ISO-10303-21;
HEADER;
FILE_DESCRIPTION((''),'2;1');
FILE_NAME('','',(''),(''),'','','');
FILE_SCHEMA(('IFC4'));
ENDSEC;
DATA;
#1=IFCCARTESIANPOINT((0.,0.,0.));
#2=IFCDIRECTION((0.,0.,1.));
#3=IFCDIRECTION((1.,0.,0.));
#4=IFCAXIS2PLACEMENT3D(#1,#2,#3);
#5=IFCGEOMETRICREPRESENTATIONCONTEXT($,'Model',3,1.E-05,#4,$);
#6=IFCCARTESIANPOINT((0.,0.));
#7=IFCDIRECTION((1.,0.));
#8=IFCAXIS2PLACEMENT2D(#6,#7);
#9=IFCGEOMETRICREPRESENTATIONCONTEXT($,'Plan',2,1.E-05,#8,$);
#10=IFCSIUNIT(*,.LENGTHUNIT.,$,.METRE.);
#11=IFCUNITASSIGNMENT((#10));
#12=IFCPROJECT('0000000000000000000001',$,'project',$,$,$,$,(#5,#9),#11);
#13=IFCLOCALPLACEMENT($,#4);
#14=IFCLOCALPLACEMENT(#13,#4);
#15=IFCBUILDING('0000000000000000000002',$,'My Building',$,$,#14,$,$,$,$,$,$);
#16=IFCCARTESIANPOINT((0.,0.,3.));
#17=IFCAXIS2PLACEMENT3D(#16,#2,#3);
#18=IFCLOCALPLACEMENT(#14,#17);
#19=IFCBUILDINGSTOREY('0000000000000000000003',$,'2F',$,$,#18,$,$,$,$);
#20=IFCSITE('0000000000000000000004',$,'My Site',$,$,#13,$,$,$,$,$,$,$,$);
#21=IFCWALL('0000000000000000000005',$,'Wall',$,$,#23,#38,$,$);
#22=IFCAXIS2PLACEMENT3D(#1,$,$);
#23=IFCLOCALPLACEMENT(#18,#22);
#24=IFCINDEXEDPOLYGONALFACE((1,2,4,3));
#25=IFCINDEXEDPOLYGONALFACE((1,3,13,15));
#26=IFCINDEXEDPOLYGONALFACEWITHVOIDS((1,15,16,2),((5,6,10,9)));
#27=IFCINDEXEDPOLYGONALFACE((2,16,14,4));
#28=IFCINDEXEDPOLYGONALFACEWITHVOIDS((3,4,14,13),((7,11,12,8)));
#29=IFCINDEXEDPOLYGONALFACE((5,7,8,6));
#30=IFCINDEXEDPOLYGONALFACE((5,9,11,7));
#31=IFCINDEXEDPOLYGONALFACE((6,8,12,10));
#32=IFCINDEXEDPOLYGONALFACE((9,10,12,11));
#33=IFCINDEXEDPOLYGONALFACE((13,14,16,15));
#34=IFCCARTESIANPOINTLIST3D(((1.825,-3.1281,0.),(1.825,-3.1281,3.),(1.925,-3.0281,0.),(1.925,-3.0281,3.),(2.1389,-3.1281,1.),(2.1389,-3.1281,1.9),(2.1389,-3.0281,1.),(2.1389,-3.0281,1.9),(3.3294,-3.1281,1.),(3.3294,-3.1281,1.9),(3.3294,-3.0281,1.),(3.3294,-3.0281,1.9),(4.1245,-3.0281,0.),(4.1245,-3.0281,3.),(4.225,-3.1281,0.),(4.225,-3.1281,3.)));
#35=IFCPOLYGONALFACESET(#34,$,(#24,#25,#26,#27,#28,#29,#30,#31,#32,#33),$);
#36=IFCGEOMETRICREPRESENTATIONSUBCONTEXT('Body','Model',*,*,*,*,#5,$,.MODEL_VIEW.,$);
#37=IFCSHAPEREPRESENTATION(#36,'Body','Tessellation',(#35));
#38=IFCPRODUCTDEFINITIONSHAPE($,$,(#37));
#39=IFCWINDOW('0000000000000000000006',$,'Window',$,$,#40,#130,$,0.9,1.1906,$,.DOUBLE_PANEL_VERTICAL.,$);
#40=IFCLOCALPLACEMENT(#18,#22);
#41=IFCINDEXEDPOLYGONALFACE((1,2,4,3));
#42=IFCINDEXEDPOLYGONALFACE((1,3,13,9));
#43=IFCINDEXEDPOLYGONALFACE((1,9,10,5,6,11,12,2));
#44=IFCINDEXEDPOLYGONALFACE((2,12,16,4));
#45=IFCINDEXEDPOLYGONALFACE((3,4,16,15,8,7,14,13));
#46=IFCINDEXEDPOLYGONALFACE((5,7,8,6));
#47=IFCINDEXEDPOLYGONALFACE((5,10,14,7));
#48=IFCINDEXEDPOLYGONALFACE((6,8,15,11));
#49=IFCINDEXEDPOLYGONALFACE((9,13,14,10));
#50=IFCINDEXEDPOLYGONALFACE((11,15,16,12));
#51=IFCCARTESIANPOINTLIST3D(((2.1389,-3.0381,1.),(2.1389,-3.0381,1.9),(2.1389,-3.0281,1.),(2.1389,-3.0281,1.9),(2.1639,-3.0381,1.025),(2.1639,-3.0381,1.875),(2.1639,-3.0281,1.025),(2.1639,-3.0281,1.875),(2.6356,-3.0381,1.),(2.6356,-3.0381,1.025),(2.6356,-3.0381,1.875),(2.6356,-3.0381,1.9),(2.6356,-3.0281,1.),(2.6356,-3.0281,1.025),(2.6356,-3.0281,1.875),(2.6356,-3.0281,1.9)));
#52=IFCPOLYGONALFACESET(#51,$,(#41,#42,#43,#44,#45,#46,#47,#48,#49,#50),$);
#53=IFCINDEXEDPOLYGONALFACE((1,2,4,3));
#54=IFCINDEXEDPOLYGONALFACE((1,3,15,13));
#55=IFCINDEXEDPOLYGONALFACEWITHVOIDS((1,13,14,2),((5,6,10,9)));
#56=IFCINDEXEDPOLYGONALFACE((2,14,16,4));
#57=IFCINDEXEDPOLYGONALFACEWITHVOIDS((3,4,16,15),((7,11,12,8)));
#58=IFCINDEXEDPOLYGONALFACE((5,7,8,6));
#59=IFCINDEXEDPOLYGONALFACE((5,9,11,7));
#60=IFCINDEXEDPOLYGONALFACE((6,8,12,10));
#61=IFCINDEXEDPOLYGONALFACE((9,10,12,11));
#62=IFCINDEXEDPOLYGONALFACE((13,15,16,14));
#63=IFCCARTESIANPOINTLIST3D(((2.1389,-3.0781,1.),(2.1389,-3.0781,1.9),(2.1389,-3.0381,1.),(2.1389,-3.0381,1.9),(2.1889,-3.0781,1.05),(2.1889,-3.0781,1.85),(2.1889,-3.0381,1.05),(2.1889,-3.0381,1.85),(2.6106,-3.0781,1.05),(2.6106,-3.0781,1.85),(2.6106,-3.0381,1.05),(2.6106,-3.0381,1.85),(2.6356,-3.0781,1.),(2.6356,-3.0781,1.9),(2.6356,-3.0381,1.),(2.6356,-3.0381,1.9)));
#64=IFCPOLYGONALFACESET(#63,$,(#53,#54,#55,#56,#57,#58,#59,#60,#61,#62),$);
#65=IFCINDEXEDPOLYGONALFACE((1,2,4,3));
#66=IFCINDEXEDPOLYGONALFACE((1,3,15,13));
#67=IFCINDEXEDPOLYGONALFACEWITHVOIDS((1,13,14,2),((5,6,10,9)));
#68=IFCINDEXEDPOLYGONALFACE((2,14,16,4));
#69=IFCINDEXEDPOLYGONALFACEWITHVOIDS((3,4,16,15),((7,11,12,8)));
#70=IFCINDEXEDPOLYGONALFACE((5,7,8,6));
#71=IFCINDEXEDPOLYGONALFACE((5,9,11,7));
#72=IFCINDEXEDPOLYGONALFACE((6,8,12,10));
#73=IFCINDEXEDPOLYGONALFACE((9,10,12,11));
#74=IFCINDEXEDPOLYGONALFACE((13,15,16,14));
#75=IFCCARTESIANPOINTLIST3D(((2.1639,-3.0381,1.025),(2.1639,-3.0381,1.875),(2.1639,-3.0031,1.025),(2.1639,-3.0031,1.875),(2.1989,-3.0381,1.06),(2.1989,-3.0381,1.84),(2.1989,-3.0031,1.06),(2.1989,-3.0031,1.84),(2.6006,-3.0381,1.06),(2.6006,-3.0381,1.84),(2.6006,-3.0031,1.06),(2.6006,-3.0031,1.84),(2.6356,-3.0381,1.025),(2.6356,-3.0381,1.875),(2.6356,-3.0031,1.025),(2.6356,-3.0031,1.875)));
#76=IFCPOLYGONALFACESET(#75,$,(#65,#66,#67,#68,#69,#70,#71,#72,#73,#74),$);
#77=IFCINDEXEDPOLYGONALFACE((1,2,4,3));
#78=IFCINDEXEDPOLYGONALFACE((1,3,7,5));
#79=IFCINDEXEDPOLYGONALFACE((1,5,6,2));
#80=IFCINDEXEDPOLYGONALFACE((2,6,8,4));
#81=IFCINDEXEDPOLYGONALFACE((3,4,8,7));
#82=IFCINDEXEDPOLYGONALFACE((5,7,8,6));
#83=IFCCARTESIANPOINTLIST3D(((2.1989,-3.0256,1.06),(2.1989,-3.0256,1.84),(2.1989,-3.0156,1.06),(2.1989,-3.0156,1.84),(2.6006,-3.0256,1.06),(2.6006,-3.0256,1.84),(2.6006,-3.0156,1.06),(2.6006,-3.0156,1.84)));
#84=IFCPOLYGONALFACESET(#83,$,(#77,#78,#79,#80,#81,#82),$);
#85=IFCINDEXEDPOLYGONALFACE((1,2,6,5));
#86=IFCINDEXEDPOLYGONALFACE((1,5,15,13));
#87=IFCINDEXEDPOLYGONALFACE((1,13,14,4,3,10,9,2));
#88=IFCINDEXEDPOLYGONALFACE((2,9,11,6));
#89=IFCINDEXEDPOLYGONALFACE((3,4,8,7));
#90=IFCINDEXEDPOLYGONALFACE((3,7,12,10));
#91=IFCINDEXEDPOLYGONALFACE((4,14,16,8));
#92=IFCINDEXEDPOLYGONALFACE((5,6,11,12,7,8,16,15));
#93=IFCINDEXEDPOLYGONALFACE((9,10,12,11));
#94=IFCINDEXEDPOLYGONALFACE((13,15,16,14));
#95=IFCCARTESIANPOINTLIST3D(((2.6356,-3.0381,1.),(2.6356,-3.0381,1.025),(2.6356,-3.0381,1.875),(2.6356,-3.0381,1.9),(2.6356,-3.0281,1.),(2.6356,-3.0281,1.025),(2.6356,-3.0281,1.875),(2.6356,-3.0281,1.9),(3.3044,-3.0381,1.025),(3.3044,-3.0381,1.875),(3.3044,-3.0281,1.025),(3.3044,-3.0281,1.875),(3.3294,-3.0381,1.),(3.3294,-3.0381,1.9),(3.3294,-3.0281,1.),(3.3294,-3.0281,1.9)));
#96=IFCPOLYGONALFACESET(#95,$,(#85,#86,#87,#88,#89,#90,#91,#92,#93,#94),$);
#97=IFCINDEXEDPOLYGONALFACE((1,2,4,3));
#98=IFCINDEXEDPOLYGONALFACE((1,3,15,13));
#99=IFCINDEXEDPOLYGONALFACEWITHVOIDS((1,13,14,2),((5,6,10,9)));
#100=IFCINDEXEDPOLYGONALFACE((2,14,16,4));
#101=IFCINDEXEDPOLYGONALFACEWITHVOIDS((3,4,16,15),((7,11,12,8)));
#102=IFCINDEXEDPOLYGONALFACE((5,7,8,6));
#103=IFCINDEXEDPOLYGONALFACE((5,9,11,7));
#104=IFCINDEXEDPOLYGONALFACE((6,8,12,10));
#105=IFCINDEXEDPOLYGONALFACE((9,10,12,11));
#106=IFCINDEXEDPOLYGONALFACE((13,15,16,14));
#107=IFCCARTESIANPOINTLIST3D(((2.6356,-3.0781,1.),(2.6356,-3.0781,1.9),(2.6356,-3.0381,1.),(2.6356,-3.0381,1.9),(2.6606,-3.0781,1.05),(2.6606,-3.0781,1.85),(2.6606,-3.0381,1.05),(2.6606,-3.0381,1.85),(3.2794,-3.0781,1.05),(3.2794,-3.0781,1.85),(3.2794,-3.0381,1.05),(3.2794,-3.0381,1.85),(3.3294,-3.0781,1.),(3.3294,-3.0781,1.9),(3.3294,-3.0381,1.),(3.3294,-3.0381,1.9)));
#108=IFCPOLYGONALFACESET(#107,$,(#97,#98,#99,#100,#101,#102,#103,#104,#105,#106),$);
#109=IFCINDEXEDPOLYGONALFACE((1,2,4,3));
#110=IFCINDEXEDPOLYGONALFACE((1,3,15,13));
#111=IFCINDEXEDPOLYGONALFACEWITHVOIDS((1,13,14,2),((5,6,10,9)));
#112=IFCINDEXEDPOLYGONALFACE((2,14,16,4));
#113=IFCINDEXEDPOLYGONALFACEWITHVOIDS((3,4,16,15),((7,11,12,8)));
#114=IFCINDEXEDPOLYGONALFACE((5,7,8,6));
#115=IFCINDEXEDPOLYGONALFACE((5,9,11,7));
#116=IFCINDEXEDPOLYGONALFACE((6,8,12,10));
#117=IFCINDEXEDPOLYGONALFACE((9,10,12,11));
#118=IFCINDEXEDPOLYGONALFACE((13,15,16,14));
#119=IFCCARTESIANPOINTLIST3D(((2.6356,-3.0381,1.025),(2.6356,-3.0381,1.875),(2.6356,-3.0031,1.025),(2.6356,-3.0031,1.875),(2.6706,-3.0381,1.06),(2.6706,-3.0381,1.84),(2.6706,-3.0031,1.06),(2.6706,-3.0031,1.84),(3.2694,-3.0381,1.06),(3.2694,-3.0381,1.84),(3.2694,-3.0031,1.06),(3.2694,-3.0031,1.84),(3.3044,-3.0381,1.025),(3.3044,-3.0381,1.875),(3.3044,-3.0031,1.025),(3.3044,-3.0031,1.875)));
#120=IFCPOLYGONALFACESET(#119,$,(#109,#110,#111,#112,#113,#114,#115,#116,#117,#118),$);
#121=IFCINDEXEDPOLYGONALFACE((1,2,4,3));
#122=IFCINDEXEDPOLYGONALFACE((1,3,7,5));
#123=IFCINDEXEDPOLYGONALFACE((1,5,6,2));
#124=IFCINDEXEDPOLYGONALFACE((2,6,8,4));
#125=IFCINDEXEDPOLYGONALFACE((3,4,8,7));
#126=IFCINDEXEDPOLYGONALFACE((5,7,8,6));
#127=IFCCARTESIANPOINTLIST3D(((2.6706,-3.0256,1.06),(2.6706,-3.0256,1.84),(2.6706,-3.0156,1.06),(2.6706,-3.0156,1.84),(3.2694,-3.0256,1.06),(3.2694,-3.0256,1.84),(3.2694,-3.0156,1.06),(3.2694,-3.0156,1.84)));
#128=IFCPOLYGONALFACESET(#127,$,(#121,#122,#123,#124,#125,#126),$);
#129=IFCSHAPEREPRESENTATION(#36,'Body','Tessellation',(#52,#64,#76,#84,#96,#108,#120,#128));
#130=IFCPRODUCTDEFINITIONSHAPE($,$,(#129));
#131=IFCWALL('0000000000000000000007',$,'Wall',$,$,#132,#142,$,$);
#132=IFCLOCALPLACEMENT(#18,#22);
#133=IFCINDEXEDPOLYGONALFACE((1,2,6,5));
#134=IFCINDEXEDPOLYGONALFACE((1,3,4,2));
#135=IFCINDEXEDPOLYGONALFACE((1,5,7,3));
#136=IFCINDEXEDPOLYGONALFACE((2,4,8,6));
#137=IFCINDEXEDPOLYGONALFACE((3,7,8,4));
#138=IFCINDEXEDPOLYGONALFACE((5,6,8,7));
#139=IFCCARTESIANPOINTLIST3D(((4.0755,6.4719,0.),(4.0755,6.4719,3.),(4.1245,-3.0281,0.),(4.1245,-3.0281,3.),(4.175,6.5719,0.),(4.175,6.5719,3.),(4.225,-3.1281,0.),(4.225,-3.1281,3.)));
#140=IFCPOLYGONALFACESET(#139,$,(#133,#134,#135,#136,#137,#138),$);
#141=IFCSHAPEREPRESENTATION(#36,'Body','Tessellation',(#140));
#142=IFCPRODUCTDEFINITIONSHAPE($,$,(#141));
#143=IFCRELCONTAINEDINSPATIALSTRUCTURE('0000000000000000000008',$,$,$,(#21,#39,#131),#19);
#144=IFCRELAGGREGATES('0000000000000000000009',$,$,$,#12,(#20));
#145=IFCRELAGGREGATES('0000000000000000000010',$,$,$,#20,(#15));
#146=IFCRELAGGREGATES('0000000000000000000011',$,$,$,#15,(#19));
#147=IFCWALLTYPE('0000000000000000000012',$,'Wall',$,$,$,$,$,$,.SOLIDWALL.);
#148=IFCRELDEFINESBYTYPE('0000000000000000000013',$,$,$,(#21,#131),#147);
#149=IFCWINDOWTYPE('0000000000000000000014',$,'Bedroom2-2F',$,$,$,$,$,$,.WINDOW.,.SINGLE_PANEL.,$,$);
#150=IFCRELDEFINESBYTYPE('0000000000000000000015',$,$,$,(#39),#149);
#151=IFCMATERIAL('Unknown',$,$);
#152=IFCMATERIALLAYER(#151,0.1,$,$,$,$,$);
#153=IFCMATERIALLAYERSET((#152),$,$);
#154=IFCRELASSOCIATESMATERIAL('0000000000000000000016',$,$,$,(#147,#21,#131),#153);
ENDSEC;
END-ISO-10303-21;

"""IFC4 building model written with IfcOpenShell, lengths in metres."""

from ifc_helpers import new_model, entity, si_unit, frame, origin_with_axes, origin_2d_with_axis, place, context, subcontext, project, spatial, line, indexed_curve, outline, extrude, shape, source, transform, mapped, material, layer, layer_set, layer_usage, type_object, type_shapes, element, fill, save


model = new_model("IFC4")

# Units and contexts
model_context = context("Model", 3, precision=1e-05, world=origin_with_axes())
plan_context = context("Plan", 2, precision=1e-05, world=origin_2d_with_axis())
body_context_1 = subcontext(model_context, "Body", "Model", "MODEL_VIEW")
body_context_2 = subcontext(plan_context, "Body", "Plan", "PLAN_VIEW")
ifc_project = project(units=[si_unit("LENGTHUNIT", "METRE")], contexts=[model_context, plan_context])

# Site, building, storey
site_placement = place(None, origin_with_axes())
site = spatial("IfcSite", under=ifc_project, at=site_placement, Name="My Site")
building_placement = place(site_placement, origin_with_axes())
building = spatial("IfcBuilding", under=site, at=building_placement, Name="My Building")
storey_placement = place(building_placement, frame((0.0, 0.0, 3.0), z_axis=(0.0, 0.0, 1.0), x_axis=(1.0, 0.0, 0.0)))
storey = spatial("IfcBuildingStorey", under=building, at=storey_placement, Name="2F")

# Shared definitions
ifc_material = material(Name="Unknown")

# Shared definitions
ifc_layer_1 = layer(ifc_material, 0.1)
ifc_layer_set_1 = layer_set([ifc_layer_1])
wall_type = type_object("IfcWallType", Name="Wall", PredefinedType="SOLIDWALL", material=ifc_layer_set_1)

# Wall, opening, window
ifc_layer_usage_1 = layer_usage(ifc_layer_set_1, "AXIS2", "POSITIVE", 0.0)
wall_1_placement = place(storey_placement, frame((1.825, -3.1281, 0.0), z_axis=(0.0, 0.0, 1.0), x_axis=(1.0, 0.0, 0.0)))
wall_1 = element("IfcWall", 1, at=wall_1_placement, inside=storey, type_object=wall_type, material=ifc_layer_usage_1, Name="Wall", context=body_context_1, shape_type="SweptSolid", body=[
    extrude(outline(indexed_curve([(0.0, 0.0), (0.1, 0.1), (2.2995, 0.1), (2.4, 0.0)], segments=[line(1, 2, 3, 4, 1)])), origin_with_axes(), (0.0, 0.0, 1.0), 3.0),
])
shared_shape_1 = source(origin_with_axes(), body_context_1, "Body", "SweptSolid", [
    extrude(outline(indexed_curve([(0.0, 0.0), (1.1906, 0.0), (1.1906, 0.9), (0.0, 0.9)], segments=[line(1, 2, 3, 4, 1)])), frame((0.0, -0.6, 0.0), z_axis=(0.0, -1.0, 0.0), x_axis=(1.0, 0.0, 0.0)), (0.0, 0.0, -1.0), 1.2),
])
opening_1_placement = place(wall_1_placement, frame((0.3139, 0.0, 1.0), z_axis=(0.0, 0.0, 1.0), x_axis=(1.0, 0.0, 0.0)))
opening_1 = element("IfcOpeningElement", 2, at=opening_1_placement, cuts=wall_1, PredefinedType="OPENING", context=body_context_1, shape_type="MappedRepresentation", body=[
    mapped(shared_shape_1, transform((0.0, 0.0, 0.0), x_axis=(1.0, 0.0, 0.0), y_axis=(0.0, 1.0, 0.0), z_axis=(0.0, 0.0, 1.0), scale=1.0)),
])
window_type_1 = type_object("IfcWindowType", Name="Bedroom2-2F", PartitioningType="SINGLE_PANEL", PredefinedType="WINDOW")
shared_shape_2 = source(origin_with_axes(), body_context_1, "Body", "SweptSolid", [
    extrude(outline(indexed_curve([(0.4967, 0.0), (0.0, 0.0), (0.0, 0.9), (0.4967, 0.9), (0.4967, 0.875), (0.025, 0.875), (0.025, 0.025), (0.4967, 0.025)], segments=[line(1, 2, 3, 4, 5, 6, 7, 8, 1)])), frame((0.0, 0.09, 0.0), z_axis=(0.0, -1.0, 0.0), x_axis=(1.0, 0.0, 0.0)), (0.0, 0.0, -1.0), 0.01),
    extrude(outline(indexed_curve([(0.0, 0.0), (0.4967, 0.0), (0.4967, 0.9), (0.0, 0.9)], segments=[line(1, 2, 3, 4, 1)]), holes=[indexed_curve([(0.05, 0.05), (0.4717, 0.05), (0.4717, 0.85), (0.05, 0.85)], segments=[line(1, 2, 3, 4, 1)])]), frame((0.0, 0.05, 0.0), z_axis=(0.0, -1.0, 0.0), x_axis=(1.0, 0.0, 0.0)), (0.0, 0.0, -1.0), 0.04),
    extrude(outline(indexed_curve([(0.0, 0.0), (0.4717, 0.0), (0.4717, 0.85), (0.0, 0.85)], segments=[line(1, 2, 3, 4, 1)]), holes=[indexed_curve([(0.035, 0.035), (0.4367, 0.035), (0.4367, 0.815), (0.035, 0.815)], segments=[line(1, 2, 3, 4, 1)])]), frame((0.025, 0.09, 0.025), z_axis=(0.0, -1.0, 0.0), x_axis=(1.0, 0.0, 0.0)), (0.0, 0.0, -1.0), 0.035),
    extrude(outline(indexed_curve([(0.035, 0.035), (0.4367, 0.035), (0.4367, 0.815), (0.035, 0.815)], segments=[line(1, 2, 3, 4, 1)])), frame((0.025, 0.1025, 0.025), z_axis=(0.0, -1.0, 0.0), x_axis=(1.0, 0.0, 0.0)), (0.0, 0.0, -1.0), 0.01),
    extrude(outline(indexed_curve([(0.0, 0.9), (0.6938, 0.9), (0.6938, 0.0), (0.0, 0.0), (0.0, 0.025), (0.6688, 0.025), (0.6688, 0.875), (0.0, 0.875)], segments=[line(1, 2, 3, 4, 5, 6, 7, 8, 1)])), frame((0.4967, 0.09, 0.0), z_axis=(0.0, -1.0, 0.0), x_axis=(1.0, 0.0, 0.0)), (0.0, 0.0, -1.0), 0.01),
    extrude(outline(indexed_curve([(0.0, 0.0), (0.6938, 0.0), (0.6938, 0.9), (0.0, 0.9)], segments=[line(1, 2, 3, 4, 1)]), holes=[indexed_curve([(0.025, 0.05), (0.6438, 0.05), (0.6438, 0.85), (0.025, 0.85)], segments=[line(1, 2, 3, 4, 1)])]), frame((0.4967, 0.05, 0.0), z_axis=(0.0, -1.0, 0.0), x_axis=(1.0, 0.0, 0.0)), (0.0, 0.0, -1.0), 0.04),
    extrude(outline(indexed_curve([(0.0, 0.0), (0.6688, 0.0), (0.6688, 0.85), (0.0, 0.85)], segments=[line(1, 2, 3, 4, 1)]), holes=[indexed_curve([(0.035, 0.035), (0.6338, 0.035), (0.6338, 0.815), (0.035, 0.815)], segments=[line(1, 2, 3, 4, 1)])]), frame((0.4967, 0.09, 0.025), z_axis=(0.0, -1.0, 0.0), x_axis=(1.0, 0.0, 0.0)), (0.0, 0.0, -1.0), 0.035),
    extrude(outline(indexed_curve([(0.035, 0.035), (0.6338, 0.035), (0.6338, 0.815), (0.035, 0.815)], segments=[line(1, 2, 3, 4, 1)])), frame((0.4967, 0.1025, 0.025), z_axis=(0.0, -1.0, 0.0), x_axis=(1.0, 0.0, 0.0)), (0.0, 0.0, -1.0), 0.01),
])
shared_shape_3 = source(origin_with_axes(), body_context_2, "Body", "Curve2D", [
    entity("IfcIndexedPolyCurve", entity("IfcCartesianPointList2D", [[0.05, 0.05], [0.4717, 0.05]])),
    entity("IfcIndexedPolyCurve", entity("IfcCartesianPointList2D", [[0.0, 0.1], [0.025, 0.1], [0.025, 0.09], [0.05, 0.09], [0.05, 0.05], [0.0, 0.05]]), [entity("IfcLineIndex", [1, 2, 3, 4, 5, 6, 1])]),
    entity("IfcIndexedPolyCurve", entity("IfcCartesianPointList2D", [[0.4967, 0.1], [0.4967, 0.1], [0.4967, 0.09], [0.4717, 0.09], [0.4717, 0.05], [0.4967, 0.05]])),
    entity("IfcIndexedPolyCurve", entity("IfcCartesianPointList2D", [[0.025, 0.09], [0.06, 0.09], [0.06, 0.125], [0.025, 0.125]]), [entity("IfcLineIndex", [1, 2, 3, 4, 1])]),
    entity("IfcIndexedPolyCurve", entity("IfcCartesianPointList2D", [[0.4967, 0.09], [0.4617, 0.09], [0.4617, 0.125], [0.4967, 0.125]]), [entity("IfcLineIndex", [1, 2, 3, 4, 1])]),
    entity("IfcIndexedPolyCurve", entity("IfcCartesianPointList2D", [[0.06, 0.09], [0.4617, 0.09]])),
    entity("IfcIndexedPolyCurve", entity("IfcCartesianPointList2D", [[0.06, 0.125], [0.4617, 0.125]])),
    entity("IfcIndexedPolyCurve", entity("IfcCartesianPointList2D", [[0.06, 0.1075], [0.4617, 0.1075]])),
    entity("IfcIndexedPolyCurve", entity("IfcCartesianPointList2D", [[0.5217, 0.05], [1.1406, 0.05]])),
    entity("IfcIndexedPolyCurve", entity("IfcCartesianPointList2D", [[0.4967, 0.1], [0.4967, 0.1], [0.4967, 0.09], [0.5217, 0.09], [0.5217, 0.05], [0.4967, 0.05]])),
    entity("IfcIndexedPolyCurve", entity("IfcCartesianPointList2D", [[1.1906, 0.1], [1.1656, 0.1], [1.1656, 0.09], [1.1406, 0.09], [1.1406, 0.05], [1.1906, 0.05]]), [entity("IfcLineIndex", [1, 2, 3, 4, 5, 6, 1])]),
    entity("IfcIndexedPolyCurve", entity("IfcCartesianPointList2D", [[0.4967, 0.09], [0.5317, 0.09], [0.5317, 0.125], [0.4967, 0.125]]), [entity("IfcLineIndex", [1, 2, 3, 4, 1])]),
    entity("IfcIndexedPolyCurve", entity("IfcCartesianPointList2D", [[1.1656, 0.09], [1.1306, 0.09], [1.1306, 0.125], [1.1656, 0.125]]), [entity("IfcLineIndex", [1, 2, 3, 4, 1])]),
    entity("IfcIndexedPolyCurve", entity("IfcCartesianPointList2D", [[0.5317, 0.09], [1.1306, 0.09]])),
    entity("IfcIndexedPolyCurve", entity("IfcCartesianPointList2D", [[0.5317, 0.125], [1.1306, 0.125]])),
    entity("IfcIndexedPolyCurve", entity("IfcCartesianPointList2D", [[0.5317, 0.1075], [1.1306, 0.1075]])),
])
type_shapes(window_type_1, [shared_shape_2, shared_shape_3])
window_1_placement = place(opening_1_placement, origin_with_axes())
window_1 = element("IfcWindow", 3, at=window_1_placement, inside=storey, type_object=window_type_1, Name="Window", OverallHeight=0.9, OverallWidth=1.1906, PartitioningType="DOUBLE_PANEL_VERTICAL", shapes=[
    shape(body_context_1, "Body", "MappedRepresentation", [mapped(shared_shape_2, transform((0.0, 0.0, 0.0), x_axis=(1.0, 0.0, 0.0), y_axis=(0.0, 1.0, 0.0), z_axis=(0.0, 0.0, 1.0), scale=1.0))]),
    shape(body_context_2, "Body", "MappedRepresentation", [mapped(shared_shape_3, transform((0.0, 0.0, 0.0), x_axis=(1.0, 0.0, 0.0), y_axis=(0.0, 1.0, 0.0), z_axis=(0.0, 0.0, 1.0), scale=1.0))]),
])
fill(opening_1, window_1)

# Wall
ifc_layer_usage_2 = layer_usage(ifc_layer_set_1, "AXIS2", "POSITIVE", 0.0)
wall_2_placement = place(storey_placement, frame((4.225, -3.1281, 0.0), z_axis=(0.0, 0.0, 1.0), x_axis=(-0.005155, 0.999987, 0.0)))
element("IfcWall", 4, at=wall_2_placement, inside=storey, type_object=wall_type, material=ifc_layer_usage_2, Name="Wall", context=body_context_1, shape_type="SweptSolid", body=[
    extrude(outline(indexed_curve([(0.0, 0.0), (0.1005, 0.1), (9.6006, 0.1), (9.7001, 0.0)], segments=[line(1, 2, 3, 4, 1)])), origin_with_axes(), (0.0, 0.0, 1.0), 3.0),
])

save(model, "model.ifc")
